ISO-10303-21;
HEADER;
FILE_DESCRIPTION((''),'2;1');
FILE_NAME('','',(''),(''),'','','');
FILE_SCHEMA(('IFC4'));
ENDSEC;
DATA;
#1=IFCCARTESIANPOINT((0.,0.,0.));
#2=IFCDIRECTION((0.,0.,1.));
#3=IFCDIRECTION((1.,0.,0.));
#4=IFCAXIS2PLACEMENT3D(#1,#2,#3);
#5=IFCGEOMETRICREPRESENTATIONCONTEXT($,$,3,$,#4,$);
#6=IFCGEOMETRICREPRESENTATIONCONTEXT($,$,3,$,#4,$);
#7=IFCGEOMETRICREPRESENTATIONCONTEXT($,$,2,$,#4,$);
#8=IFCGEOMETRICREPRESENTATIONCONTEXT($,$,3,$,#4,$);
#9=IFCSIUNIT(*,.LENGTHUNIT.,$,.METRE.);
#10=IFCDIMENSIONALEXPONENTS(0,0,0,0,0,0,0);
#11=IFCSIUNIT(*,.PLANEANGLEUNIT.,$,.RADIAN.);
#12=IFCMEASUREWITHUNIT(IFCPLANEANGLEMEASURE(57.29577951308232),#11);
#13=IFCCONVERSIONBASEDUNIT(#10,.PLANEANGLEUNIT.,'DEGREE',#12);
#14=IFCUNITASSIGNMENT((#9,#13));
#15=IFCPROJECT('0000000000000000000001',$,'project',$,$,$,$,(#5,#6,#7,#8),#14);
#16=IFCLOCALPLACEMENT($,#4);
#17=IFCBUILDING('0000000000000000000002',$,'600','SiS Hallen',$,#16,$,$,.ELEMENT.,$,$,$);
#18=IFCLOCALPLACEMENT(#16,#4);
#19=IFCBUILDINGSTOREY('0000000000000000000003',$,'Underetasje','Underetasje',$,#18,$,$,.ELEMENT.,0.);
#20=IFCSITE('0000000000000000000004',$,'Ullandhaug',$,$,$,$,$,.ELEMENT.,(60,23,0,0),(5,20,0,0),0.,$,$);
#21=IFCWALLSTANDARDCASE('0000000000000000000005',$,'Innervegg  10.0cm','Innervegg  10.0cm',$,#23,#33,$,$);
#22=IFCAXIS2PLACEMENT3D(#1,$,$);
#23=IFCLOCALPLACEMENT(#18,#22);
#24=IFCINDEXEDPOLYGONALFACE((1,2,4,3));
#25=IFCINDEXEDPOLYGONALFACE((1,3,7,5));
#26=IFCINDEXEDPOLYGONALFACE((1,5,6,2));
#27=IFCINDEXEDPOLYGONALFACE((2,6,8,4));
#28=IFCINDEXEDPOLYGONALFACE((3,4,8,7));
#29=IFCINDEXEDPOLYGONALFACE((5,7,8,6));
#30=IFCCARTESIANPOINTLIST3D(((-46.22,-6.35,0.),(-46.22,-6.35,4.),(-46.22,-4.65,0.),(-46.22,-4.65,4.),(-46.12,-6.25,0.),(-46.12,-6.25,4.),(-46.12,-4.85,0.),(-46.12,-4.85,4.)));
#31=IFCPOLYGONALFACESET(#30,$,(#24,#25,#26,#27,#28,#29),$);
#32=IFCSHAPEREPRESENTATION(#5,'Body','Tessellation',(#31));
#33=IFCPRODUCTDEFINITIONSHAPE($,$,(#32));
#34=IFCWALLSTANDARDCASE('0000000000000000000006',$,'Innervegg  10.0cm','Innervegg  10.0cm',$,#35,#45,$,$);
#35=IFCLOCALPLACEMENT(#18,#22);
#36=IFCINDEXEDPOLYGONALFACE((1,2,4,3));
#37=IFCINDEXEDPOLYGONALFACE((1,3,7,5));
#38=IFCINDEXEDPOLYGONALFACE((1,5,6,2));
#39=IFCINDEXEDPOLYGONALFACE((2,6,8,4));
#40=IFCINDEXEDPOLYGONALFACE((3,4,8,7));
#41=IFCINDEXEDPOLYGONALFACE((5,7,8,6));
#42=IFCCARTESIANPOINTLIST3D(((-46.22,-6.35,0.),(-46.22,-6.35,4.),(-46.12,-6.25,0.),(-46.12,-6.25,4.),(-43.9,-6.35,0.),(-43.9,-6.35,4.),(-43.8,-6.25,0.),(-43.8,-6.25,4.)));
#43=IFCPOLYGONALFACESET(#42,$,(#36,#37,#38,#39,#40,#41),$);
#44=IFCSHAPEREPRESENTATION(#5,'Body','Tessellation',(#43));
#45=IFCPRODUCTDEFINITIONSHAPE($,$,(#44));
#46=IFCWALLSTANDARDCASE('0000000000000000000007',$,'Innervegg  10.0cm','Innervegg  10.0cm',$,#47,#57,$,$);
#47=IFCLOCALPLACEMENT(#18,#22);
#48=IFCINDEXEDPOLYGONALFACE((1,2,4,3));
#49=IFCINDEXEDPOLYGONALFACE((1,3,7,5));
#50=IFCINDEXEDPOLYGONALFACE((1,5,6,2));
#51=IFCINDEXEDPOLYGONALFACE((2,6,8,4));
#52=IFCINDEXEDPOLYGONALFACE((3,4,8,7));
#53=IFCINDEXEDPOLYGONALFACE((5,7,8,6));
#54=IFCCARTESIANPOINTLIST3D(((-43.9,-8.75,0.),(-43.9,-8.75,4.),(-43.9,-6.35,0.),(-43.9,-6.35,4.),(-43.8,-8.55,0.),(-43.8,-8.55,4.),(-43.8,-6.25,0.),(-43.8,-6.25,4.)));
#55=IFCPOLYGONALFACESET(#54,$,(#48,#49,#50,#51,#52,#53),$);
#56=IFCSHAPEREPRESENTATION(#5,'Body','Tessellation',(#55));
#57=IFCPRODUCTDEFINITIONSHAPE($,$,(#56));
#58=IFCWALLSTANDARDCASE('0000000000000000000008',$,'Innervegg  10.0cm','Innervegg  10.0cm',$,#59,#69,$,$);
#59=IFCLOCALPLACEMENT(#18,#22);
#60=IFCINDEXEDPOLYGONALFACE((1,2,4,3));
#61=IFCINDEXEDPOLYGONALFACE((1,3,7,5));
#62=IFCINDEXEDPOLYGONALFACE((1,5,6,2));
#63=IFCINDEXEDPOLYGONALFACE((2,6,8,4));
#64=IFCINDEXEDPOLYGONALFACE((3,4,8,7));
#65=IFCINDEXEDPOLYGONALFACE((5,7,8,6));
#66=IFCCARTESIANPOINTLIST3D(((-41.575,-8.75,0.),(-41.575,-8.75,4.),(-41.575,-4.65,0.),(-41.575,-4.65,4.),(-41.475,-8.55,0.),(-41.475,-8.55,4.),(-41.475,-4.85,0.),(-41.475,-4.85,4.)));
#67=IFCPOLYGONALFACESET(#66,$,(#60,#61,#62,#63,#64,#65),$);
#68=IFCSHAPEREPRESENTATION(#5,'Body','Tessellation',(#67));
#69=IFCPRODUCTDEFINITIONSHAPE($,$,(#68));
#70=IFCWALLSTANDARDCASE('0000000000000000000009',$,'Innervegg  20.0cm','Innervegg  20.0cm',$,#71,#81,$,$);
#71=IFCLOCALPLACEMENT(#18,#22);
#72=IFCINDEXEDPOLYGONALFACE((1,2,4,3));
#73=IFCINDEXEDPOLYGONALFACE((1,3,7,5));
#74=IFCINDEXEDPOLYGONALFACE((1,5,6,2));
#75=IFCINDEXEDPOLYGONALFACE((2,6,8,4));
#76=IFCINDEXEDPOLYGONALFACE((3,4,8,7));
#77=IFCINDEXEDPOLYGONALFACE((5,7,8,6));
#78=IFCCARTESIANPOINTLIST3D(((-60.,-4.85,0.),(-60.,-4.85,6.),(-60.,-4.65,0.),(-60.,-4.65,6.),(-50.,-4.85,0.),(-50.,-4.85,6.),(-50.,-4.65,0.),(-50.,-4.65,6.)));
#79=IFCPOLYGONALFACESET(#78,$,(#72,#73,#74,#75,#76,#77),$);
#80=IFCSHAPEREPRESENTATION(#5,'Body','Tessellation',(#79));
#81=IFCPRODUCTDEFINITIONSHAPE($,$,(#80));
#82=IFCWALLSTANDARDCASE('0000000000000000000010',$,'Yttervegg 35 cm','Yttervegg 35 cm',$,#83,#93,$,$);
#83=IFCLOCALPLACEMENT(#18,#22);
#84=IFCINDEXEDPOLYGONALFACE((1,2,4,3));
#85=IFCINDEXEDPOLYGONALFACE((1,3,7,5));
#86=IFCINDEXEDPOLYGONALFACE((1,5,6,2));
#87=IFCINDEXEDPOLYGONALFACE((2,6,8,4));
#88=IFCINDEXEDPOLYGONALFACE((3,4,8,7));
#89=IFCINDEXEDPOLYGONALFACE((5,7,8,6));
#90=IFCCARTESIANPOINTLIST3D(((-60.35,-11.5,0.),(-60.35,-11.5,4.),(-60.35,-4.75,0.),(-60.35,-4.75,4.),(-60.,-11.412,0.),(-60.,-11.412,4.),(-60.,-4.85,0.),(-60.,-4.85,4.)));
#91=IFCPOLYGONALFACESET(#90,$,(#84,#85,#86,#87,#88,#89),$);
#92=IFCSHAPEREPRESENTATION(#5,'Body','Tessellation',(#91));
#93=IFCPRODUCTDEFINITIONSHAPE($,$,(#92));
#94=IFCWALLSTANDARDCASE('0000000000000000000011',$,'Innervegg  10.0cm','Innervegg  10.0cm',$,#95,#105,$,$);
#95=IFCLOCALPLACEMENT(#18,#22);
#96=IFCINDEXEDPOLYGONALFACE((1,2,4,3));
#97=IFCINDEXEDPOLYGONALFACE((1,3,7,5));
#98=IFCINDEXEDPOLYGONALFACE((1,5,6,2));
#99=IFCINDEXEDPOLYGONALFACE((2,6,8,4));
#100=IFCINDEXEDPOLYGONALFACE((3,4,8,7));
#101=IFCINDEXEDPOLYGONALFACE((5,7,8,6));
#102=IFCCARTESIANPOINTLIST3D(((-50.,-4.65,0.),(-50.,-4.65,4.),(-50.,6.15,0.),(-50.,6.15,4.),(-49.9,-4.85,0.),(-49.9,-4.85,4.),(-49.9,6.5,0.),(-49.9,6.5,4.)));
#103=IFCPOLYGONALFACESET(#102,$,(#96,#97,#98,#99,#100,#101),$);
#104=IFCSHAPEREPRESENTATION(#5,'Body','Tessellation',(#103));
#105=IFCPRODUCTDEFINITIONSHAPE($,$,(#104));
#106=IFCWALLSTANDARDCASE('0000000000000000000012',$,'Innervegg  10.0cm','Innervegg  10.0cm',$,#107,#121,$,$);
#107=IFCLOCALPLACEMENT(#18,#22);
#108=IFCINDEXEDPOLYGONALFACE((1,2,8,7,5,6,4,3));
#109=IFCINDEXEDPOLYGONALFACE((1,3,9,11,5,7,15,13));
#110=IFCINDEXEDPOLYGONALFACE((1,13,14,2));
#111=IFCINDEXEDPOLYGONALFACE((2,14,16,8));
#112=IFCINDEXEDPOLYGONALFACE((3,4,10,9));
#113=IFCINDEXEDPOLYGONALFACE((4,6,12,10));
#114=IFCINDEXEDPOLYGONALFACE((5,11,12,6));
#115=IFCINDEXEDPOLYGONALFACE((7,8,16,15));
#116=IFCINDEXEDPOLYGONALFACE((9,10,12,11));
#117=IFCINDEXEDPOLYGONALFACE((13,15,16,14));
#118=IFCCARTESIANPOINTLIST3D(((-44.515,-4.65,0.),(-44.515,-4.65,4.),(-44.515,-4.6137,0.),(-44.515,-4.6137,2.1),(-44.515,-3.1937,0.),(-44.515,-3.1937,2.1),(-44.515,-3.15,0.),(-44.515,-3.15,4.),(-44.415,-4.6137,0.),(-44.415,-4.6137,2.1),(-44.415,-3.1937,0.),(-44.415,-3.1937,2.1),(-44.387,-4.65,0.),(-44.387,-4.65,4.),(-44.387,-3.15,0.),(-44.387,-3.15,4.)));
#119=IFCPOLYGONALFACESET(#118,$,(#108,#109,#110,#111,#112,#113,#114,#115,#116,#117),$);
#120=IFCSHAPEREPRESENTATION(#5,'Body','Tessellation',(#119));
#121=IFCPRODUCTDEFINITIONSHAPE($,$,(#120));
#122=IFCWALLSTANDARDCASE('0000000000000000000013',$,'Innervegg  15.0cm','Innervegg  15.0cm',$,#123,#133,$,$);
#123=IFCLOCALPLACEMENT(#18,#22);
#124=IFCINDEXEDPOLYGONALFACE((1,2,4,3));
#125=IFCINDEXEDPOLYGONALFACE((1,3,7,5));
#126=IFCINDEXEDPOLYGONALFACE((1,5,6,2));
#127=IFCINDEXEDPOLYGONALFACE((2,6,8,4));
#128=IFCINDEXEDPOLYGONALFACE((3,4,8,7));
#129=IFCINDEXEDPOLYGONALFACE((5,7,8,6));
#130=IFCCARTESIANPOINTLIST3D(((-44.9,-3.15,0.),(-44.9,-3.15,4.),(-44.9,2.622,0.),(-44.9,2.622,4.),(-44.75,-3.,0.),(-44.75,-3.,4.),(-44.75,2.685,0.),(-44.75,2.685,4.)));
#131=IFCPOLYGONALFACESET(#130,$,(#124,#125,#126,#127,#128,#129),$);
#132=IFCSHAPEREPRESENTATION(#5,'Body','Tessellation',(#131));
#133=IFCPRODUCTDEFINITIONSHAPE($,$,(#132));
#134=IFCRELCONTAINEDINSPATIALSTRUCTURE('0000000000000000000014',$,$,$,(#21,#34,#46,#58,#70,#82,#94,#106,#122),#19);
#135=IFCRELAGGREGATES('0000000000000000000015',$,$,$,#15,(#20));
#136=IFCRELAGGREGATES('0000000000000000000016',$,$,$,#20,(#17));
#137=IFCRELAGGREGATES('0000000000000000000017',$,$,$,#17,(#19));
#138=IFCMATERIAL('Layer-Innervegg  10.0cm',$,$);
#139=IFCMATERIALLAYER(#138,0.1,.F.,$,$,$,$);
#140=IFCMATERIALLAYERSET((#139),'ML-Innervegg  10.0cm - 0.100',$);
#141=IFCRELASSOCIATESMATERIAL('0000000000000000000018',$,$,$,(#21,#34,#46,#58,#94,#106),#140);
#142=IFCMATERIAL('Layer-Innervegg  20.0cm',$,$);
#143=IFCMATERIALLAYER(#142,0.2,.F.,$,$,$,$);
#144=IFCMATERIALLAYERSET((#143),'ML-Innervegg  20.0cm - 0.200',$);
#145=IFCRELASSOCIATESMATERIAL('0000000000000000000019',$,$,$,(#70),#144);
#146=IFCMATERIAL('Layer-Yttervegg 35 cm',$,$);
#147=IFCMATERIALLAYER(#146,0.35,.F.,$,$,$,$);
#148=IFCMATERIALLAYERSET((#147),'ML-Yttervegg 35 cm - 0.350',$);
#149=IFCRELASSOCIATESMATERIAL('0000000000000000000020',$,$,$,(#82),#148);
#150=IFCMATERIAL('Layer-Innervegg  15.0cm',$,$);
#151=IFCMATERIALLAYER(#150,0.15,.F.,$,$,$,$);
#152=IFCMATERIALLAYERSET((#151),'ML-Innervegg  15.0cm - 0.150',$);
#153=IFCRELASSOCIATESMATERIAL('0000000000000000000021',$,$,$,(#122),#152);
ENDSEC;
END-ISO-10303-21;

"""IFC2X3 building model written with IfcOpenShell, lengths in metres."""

from ifc_helpers import new_model, entity, si_unit, converted_unit, frame, origin_with_axes, place, context, project, spatial, polyline, outline, extrude, material, layer, layer_set, layer_usage, element, save


model = new_model("IFC2X3")

# Units and contexts
context_of_model_1 = context(None, 3, world=origin_with_axes())
context_of_model_2 = context(None, 3, world=origin_with_axes())
context_of_model_3 = context(None, 2, world=origin_with_axes())
context_of_model_4 = context(None, 3, world=origin_with_axes())
ifc_project = project(units=[si_unit("LENGTHUNIT", "METRE"), converted_unit("PLANEANGLEUNIT", "DEGREE", entity("IfcPlaneAngleMeasure", 57.29577951308232), si_unit("PLANEANGLEUNIT", "RADIAN"), dimensions=[0, 0, 0, 0, 0, 0, 0])], contexts=[context_of_model_1, context_of_model_2, context_of_model_3, context_of_model_4])

# Site, building, storey
site = spatial("IfcSite", under=ifc_project, Name="Ullandhaug", CompositionType="ELEMENT", RefLatitude=(60, 23, 0, 0), RefLongitude=(5, 20, 0, 0), RefElevation=0.0)
building_placement = place(None, origin_with_axes())
building = spatial("IfcBuilding", under=site, at=building_placement, Name="600", Description="SiS Hallen", CompositionType="ELEMENT")
storey_placement = place(building_placement, origin_with_axes())
storey = spatial("IfcBuildingStorey", under=building, at=storey_placement, Name="Underetasje", Description="Underetasje", CompositionType="ELEMENT", Elevation=0.0)

# Shared definitions
ifc_material_1 = material(Name="Layer-Innervegg  20.0cm")
ifc_layer_1 = layer(ifc_material_1, 0.2, ventilated=False)
ifc_layer_set_1 = layer_set([ifc_layer_1], Name="ML-Innervegg  20.0cm - 0.200")
ifc_layer_usage_1 = layer_usage(ifc_layer_set_1, "AXIS2", "POSITIVE", 0.0)

# Walls
ifc_material_2 = material(Name="Layer-Innervegg  10.0cm")
ifc_layer_2 = layer(ifc_material_2, 0.1, ventilated=False)
ifc_layer_set_2 = layer_set([ifc_layer_2], Name="ML-Innervegg  10.0cm - 0.100")
ifc_layer_usage_2 = layer_usage(ifc_layer_set_2, "AXIS2", "POSITIVE", 0.0)
wall_1_placement = place(storey_placement, frame((-46.22, -4.65, 0.0), z_axis=(0.0, 0.0, 1.0), x_axis=(0.0, -1.0, 0.0)))
element("IfcWallStandardCase", 1, at=wall_1_placement, inside=storey, material=ifc_layer_usage_2, Name="Innervegg  10.0cm", Description="Innervegg  10.0cm", context=context_of_model_1, shape_type="SweptSolid", body=[
    extrude(outline(polyline([(0.0, 0.0), (1.7, 0.0), (1.6, 0.1), (0.2, 0.1), (0.0, 0.0)])), frame((0.0, 0.0, 0.0), z_axis=(0.0, 0.0, 1.0), x_axis=(1.0, 0.0, 0.0)), (0.0, 0.0, 1.0), 4.0),
])
wall_2_placement = place(storey_placement, frame((-46.22, -6.35, 0.0), z_axis=(0.0, 0.0, 1.0), x_axis=(1.0, 0.0, 0.0)))
element("IfcWallStandardCase", 2, at=wall_2_placement, inside=storey, material=ifc_layer_usage_2, Name="Innervegg  10.0cm", Description="Innervegg  10.0cm", context=context_of_model_1, shape_type="SweptSolid", body=[
    extrude(outline(polyline([(0.0, 0.0), (2.32, 0.0), (2.42, 0.1), (0.1, 0.1), (0.0, 0.0)])), origin_with_axes(), (0.0, 0.0, 1.0), 4.0),
])
wall_3_placement = place(storey_placement, frame((-43.9, -6.35, 0.0), z_axis=(0.0, 0.0, 1.0), x_axis=(0.0, -1.0, 0.0)))
element("IfcWallStandardCase", 3, at=wall_3_placement, inside=storey, material=ifc_layer_usage_2, Name="Innervegg  10.0cm", Description="Innervegg  10.0cm", context=context_of_model_1, shape_type="SweptSolid", body=[
    extrude(outline(polyline([(0.0, 0.0), (2.4, 0.0), (2.2, 0.1), (-0.1, 0.1), (0.0, 0.0)])), frame((0.0, 0.0, 0.0), z_axis=(0.0, 0.0, 1.0), x_axis=(1.0, 0.0, 0.0)), (0.0, 0.0, 1.0), 4.0),
])
wall_4_placement = place(storey_placement, frame((-41.575, -4.65, 0.0), z_axis=(0.0, 0.0, 1.0), x_axis=(0.0, -1.0, 0.0)))
element("IfcWallStandardCase", 4, at=wall_4_placement, inside=storey, material=ifc_layer_usage_2, Name="Innervegg  10.0cm", Description="Innervegg  10.0cm", context=context_of_model_1, shape_type="SweptSolid", body=[
    extrude(outline(polyline([(0.0, 0.0), (4.1, 0.0), (3.9, 0.1), (0.2, 0.1), (0.0, 0.0)])), frame((0.0, 0.0, 0.0), z_axis=(0.0, 0.0, 1.0), x_axis=(1.0, 0.0, 0.0)), (0.0, 0.0, 1.0), 4.0),
])
wall_5_placement = place(storey_placement, frame((-50.0, -4.65, 0.0), z_axis=(0.0, 0.0, 1.0), x_axis=(-1.0, 0.0, 0.0)))
element("IfcWallStandardCase", 5, at=wall_5_placement, inside=storey, material=ifc_layer_usage_1, Name="Innervegg  20.0cm", Description="Innervegg  20.0cm", context=context_of_model_1, shape_type="SweptSolid", body=[
    extrude(outline(polyline([(0.0, 0.0), (10.0, 0.0), (10.0, 0.2), (0.0, 0.2), (0.0, 0.0)])), frame((0.0, 0.0, 0.0), z_axis=(0.0, 0.0, 1.0), x_axis=(1.0, 0.0, 0.0)), (0.0, 0.0, 1.0), 6.0),
])
ifc_material_3 = material(Name="Layer-Yttervegg 35 cm")
ifc_layer_3 = layer(ifc_material_3, 0.35, ventilated=False)
ifc_layer_set_3 = layer_set([ifc_layer_3], Name="ML-Yttervegg 35 cm - 0.350")
ifc_layer_usage_3 = layer_usage(ifc_layer_set_3, "AXIS2", "POSITIVE", 0.0)
wall_6_placement = place(storey_placement, frame((-60.35, -4.75, 0.0), z_axis=(0.0, 0.0, 1.0), x_axis=(0.0, -1.0, 0.0)))
element("IfcWallStandardCase", 6, at=wall_6_placement, inside=storey, material=ifc_layer_usage_3, Name="Yttervegg 35 cm", Description="Yttervegg 35 cm", context=context_of_model_1, shape_type="SweptSolid", body=[
    extrude(outline(polyline([(0.0, 0.0), (6.75, 0.0), (6.662, 0.35), (0.1, 0.35), (0.0, 0.0)])), frame((0.0, 0.0, 0.0), z_axis=(0.0, 0.0, 1.0), x_axis=(1.0, 0.0, 0.0)), (0.0, 0.0, 1.0), 4.0),
])
wall_7_placement = place(storey_placement, frame((-49.9, -4.85, 0.0), z_axis=(0.0, 0.0, 1.0), x_axis=(0.0, 1.0, 0.0)))
element("IfcWallStandardCase", 7, at=wall_7_placement, inside=storey, material=ifc_layer_usage_2, Name="Innervegg  10.0cm", Description="Innervegg  10.0cm", context=context_of_model_1, shape_type="SweptSolid", body=[
    extrude(outline(polyline([(0.0, 0.0), (11.35, 0.0), (11.0, 0.1), (0.2, 0.1), (0.0, 0.0)])), frame((0.0, 0.0, 0.0), z_axis=(0.0, 0.0, 1.0), x_axis=(1.0, 0.0, 0.0)), (0.0, 0.0, 1.0), 4.0),
])

# Wall, opening
wall_8_placement = place(storey_placement, frame((-44.387, -4.65, 0.0), z_axis=(0.0, 0.0, 1.0), x_axis=(0.0, 1.0, 0.0)))
wall_8 = element("IfcWallStandardCase", 8, at=wall_8_placement, inside=storey, material=ifc_layer_usage_2, Name="Innervegg  10.0cm", Description="Innervegg  10.0cm", context=context_of_model_1, shape_type="SweptSolid", body=[
    extrude(outline(polyline([(0.0, 0.0), (1.5, 0.0), (1.5, 0.128), (0.0, 0.128), (0.0, 0.0)])), frame((0.0, 0.0, 0.0), z_axis=(0.0, 0.0, 1.0), x_axis=(1.0, 0.0, 0.0)), (0.0, 0.0, 1.0), 4.0),
])
opening_1_placement = place(wall_8_placement, frame((0.0363, 0.128, 0.0), z_axis=(0.0, 0.0, 1.0), x_axis=(1.0, 0.0, 0.0)))
element("IfcOpeningElement", 9, at=opening_1_placement, cuts=wall_8, context=context_of_model_1, shape_type="SweptSolid", body=[
    extrude(outline(polyline([(0.0, 0.0), (2.1, 0.0), (2.1, 1.42), (0.0, 1.42), (0.0, 0.0)])), frame((0.0, 0.0, 0.0), z_axis=(0.0, 1.0, 0.0), x_axis=(0.0, 0.0, 1.0)), (0.0, 0.0, -1.0), 0.1),
])

# Wall
ifc_material_4 = material(Name="Layer-Innervegg  15.0cm")
ifc_layer_4 = layer(ifc_material_4, 0.15, ventilated=False)
ifc_layer_set_4 = layer_set([ifc_layer_4], Name="ML-Innervegg  15.0cm - 0.150")
ifc_layer_usage_4 = layer_usage(ifc_layer_set_4, "AXIS2", "POSITIVE", 0.0)
wall_9_placement = place(storey_placement, frame((-44.75, -3.0, 0.0), z_axis=(0.0, 0.0, 1.0), x_axis=(0.0, 1.0, 0.0)))
element("IfcWallStandardCase", 10, at=wall_9_placement, inside=storey, material=ifc_layer_usage_4, Name="Innervegg  15.0cm", Description="Innervegg  15.0cm", context=context_of_model_1, shape_type="SweptSolid", body=[
    extrude(outline(polyline([(0.0, 0.0), (5.685, 0.0), (5.622, 0.15), (-0.15, 0.15), (0.0, 0.0)])), frame((0.0, 0.0, 0.0), z_axis=(0.0, 0.0, 1.0), x_axis=(1.0, 0.0, 0.0)), (0.0, 0.0, 1.0), 4.0),
])

save(model, "model.ifc")
